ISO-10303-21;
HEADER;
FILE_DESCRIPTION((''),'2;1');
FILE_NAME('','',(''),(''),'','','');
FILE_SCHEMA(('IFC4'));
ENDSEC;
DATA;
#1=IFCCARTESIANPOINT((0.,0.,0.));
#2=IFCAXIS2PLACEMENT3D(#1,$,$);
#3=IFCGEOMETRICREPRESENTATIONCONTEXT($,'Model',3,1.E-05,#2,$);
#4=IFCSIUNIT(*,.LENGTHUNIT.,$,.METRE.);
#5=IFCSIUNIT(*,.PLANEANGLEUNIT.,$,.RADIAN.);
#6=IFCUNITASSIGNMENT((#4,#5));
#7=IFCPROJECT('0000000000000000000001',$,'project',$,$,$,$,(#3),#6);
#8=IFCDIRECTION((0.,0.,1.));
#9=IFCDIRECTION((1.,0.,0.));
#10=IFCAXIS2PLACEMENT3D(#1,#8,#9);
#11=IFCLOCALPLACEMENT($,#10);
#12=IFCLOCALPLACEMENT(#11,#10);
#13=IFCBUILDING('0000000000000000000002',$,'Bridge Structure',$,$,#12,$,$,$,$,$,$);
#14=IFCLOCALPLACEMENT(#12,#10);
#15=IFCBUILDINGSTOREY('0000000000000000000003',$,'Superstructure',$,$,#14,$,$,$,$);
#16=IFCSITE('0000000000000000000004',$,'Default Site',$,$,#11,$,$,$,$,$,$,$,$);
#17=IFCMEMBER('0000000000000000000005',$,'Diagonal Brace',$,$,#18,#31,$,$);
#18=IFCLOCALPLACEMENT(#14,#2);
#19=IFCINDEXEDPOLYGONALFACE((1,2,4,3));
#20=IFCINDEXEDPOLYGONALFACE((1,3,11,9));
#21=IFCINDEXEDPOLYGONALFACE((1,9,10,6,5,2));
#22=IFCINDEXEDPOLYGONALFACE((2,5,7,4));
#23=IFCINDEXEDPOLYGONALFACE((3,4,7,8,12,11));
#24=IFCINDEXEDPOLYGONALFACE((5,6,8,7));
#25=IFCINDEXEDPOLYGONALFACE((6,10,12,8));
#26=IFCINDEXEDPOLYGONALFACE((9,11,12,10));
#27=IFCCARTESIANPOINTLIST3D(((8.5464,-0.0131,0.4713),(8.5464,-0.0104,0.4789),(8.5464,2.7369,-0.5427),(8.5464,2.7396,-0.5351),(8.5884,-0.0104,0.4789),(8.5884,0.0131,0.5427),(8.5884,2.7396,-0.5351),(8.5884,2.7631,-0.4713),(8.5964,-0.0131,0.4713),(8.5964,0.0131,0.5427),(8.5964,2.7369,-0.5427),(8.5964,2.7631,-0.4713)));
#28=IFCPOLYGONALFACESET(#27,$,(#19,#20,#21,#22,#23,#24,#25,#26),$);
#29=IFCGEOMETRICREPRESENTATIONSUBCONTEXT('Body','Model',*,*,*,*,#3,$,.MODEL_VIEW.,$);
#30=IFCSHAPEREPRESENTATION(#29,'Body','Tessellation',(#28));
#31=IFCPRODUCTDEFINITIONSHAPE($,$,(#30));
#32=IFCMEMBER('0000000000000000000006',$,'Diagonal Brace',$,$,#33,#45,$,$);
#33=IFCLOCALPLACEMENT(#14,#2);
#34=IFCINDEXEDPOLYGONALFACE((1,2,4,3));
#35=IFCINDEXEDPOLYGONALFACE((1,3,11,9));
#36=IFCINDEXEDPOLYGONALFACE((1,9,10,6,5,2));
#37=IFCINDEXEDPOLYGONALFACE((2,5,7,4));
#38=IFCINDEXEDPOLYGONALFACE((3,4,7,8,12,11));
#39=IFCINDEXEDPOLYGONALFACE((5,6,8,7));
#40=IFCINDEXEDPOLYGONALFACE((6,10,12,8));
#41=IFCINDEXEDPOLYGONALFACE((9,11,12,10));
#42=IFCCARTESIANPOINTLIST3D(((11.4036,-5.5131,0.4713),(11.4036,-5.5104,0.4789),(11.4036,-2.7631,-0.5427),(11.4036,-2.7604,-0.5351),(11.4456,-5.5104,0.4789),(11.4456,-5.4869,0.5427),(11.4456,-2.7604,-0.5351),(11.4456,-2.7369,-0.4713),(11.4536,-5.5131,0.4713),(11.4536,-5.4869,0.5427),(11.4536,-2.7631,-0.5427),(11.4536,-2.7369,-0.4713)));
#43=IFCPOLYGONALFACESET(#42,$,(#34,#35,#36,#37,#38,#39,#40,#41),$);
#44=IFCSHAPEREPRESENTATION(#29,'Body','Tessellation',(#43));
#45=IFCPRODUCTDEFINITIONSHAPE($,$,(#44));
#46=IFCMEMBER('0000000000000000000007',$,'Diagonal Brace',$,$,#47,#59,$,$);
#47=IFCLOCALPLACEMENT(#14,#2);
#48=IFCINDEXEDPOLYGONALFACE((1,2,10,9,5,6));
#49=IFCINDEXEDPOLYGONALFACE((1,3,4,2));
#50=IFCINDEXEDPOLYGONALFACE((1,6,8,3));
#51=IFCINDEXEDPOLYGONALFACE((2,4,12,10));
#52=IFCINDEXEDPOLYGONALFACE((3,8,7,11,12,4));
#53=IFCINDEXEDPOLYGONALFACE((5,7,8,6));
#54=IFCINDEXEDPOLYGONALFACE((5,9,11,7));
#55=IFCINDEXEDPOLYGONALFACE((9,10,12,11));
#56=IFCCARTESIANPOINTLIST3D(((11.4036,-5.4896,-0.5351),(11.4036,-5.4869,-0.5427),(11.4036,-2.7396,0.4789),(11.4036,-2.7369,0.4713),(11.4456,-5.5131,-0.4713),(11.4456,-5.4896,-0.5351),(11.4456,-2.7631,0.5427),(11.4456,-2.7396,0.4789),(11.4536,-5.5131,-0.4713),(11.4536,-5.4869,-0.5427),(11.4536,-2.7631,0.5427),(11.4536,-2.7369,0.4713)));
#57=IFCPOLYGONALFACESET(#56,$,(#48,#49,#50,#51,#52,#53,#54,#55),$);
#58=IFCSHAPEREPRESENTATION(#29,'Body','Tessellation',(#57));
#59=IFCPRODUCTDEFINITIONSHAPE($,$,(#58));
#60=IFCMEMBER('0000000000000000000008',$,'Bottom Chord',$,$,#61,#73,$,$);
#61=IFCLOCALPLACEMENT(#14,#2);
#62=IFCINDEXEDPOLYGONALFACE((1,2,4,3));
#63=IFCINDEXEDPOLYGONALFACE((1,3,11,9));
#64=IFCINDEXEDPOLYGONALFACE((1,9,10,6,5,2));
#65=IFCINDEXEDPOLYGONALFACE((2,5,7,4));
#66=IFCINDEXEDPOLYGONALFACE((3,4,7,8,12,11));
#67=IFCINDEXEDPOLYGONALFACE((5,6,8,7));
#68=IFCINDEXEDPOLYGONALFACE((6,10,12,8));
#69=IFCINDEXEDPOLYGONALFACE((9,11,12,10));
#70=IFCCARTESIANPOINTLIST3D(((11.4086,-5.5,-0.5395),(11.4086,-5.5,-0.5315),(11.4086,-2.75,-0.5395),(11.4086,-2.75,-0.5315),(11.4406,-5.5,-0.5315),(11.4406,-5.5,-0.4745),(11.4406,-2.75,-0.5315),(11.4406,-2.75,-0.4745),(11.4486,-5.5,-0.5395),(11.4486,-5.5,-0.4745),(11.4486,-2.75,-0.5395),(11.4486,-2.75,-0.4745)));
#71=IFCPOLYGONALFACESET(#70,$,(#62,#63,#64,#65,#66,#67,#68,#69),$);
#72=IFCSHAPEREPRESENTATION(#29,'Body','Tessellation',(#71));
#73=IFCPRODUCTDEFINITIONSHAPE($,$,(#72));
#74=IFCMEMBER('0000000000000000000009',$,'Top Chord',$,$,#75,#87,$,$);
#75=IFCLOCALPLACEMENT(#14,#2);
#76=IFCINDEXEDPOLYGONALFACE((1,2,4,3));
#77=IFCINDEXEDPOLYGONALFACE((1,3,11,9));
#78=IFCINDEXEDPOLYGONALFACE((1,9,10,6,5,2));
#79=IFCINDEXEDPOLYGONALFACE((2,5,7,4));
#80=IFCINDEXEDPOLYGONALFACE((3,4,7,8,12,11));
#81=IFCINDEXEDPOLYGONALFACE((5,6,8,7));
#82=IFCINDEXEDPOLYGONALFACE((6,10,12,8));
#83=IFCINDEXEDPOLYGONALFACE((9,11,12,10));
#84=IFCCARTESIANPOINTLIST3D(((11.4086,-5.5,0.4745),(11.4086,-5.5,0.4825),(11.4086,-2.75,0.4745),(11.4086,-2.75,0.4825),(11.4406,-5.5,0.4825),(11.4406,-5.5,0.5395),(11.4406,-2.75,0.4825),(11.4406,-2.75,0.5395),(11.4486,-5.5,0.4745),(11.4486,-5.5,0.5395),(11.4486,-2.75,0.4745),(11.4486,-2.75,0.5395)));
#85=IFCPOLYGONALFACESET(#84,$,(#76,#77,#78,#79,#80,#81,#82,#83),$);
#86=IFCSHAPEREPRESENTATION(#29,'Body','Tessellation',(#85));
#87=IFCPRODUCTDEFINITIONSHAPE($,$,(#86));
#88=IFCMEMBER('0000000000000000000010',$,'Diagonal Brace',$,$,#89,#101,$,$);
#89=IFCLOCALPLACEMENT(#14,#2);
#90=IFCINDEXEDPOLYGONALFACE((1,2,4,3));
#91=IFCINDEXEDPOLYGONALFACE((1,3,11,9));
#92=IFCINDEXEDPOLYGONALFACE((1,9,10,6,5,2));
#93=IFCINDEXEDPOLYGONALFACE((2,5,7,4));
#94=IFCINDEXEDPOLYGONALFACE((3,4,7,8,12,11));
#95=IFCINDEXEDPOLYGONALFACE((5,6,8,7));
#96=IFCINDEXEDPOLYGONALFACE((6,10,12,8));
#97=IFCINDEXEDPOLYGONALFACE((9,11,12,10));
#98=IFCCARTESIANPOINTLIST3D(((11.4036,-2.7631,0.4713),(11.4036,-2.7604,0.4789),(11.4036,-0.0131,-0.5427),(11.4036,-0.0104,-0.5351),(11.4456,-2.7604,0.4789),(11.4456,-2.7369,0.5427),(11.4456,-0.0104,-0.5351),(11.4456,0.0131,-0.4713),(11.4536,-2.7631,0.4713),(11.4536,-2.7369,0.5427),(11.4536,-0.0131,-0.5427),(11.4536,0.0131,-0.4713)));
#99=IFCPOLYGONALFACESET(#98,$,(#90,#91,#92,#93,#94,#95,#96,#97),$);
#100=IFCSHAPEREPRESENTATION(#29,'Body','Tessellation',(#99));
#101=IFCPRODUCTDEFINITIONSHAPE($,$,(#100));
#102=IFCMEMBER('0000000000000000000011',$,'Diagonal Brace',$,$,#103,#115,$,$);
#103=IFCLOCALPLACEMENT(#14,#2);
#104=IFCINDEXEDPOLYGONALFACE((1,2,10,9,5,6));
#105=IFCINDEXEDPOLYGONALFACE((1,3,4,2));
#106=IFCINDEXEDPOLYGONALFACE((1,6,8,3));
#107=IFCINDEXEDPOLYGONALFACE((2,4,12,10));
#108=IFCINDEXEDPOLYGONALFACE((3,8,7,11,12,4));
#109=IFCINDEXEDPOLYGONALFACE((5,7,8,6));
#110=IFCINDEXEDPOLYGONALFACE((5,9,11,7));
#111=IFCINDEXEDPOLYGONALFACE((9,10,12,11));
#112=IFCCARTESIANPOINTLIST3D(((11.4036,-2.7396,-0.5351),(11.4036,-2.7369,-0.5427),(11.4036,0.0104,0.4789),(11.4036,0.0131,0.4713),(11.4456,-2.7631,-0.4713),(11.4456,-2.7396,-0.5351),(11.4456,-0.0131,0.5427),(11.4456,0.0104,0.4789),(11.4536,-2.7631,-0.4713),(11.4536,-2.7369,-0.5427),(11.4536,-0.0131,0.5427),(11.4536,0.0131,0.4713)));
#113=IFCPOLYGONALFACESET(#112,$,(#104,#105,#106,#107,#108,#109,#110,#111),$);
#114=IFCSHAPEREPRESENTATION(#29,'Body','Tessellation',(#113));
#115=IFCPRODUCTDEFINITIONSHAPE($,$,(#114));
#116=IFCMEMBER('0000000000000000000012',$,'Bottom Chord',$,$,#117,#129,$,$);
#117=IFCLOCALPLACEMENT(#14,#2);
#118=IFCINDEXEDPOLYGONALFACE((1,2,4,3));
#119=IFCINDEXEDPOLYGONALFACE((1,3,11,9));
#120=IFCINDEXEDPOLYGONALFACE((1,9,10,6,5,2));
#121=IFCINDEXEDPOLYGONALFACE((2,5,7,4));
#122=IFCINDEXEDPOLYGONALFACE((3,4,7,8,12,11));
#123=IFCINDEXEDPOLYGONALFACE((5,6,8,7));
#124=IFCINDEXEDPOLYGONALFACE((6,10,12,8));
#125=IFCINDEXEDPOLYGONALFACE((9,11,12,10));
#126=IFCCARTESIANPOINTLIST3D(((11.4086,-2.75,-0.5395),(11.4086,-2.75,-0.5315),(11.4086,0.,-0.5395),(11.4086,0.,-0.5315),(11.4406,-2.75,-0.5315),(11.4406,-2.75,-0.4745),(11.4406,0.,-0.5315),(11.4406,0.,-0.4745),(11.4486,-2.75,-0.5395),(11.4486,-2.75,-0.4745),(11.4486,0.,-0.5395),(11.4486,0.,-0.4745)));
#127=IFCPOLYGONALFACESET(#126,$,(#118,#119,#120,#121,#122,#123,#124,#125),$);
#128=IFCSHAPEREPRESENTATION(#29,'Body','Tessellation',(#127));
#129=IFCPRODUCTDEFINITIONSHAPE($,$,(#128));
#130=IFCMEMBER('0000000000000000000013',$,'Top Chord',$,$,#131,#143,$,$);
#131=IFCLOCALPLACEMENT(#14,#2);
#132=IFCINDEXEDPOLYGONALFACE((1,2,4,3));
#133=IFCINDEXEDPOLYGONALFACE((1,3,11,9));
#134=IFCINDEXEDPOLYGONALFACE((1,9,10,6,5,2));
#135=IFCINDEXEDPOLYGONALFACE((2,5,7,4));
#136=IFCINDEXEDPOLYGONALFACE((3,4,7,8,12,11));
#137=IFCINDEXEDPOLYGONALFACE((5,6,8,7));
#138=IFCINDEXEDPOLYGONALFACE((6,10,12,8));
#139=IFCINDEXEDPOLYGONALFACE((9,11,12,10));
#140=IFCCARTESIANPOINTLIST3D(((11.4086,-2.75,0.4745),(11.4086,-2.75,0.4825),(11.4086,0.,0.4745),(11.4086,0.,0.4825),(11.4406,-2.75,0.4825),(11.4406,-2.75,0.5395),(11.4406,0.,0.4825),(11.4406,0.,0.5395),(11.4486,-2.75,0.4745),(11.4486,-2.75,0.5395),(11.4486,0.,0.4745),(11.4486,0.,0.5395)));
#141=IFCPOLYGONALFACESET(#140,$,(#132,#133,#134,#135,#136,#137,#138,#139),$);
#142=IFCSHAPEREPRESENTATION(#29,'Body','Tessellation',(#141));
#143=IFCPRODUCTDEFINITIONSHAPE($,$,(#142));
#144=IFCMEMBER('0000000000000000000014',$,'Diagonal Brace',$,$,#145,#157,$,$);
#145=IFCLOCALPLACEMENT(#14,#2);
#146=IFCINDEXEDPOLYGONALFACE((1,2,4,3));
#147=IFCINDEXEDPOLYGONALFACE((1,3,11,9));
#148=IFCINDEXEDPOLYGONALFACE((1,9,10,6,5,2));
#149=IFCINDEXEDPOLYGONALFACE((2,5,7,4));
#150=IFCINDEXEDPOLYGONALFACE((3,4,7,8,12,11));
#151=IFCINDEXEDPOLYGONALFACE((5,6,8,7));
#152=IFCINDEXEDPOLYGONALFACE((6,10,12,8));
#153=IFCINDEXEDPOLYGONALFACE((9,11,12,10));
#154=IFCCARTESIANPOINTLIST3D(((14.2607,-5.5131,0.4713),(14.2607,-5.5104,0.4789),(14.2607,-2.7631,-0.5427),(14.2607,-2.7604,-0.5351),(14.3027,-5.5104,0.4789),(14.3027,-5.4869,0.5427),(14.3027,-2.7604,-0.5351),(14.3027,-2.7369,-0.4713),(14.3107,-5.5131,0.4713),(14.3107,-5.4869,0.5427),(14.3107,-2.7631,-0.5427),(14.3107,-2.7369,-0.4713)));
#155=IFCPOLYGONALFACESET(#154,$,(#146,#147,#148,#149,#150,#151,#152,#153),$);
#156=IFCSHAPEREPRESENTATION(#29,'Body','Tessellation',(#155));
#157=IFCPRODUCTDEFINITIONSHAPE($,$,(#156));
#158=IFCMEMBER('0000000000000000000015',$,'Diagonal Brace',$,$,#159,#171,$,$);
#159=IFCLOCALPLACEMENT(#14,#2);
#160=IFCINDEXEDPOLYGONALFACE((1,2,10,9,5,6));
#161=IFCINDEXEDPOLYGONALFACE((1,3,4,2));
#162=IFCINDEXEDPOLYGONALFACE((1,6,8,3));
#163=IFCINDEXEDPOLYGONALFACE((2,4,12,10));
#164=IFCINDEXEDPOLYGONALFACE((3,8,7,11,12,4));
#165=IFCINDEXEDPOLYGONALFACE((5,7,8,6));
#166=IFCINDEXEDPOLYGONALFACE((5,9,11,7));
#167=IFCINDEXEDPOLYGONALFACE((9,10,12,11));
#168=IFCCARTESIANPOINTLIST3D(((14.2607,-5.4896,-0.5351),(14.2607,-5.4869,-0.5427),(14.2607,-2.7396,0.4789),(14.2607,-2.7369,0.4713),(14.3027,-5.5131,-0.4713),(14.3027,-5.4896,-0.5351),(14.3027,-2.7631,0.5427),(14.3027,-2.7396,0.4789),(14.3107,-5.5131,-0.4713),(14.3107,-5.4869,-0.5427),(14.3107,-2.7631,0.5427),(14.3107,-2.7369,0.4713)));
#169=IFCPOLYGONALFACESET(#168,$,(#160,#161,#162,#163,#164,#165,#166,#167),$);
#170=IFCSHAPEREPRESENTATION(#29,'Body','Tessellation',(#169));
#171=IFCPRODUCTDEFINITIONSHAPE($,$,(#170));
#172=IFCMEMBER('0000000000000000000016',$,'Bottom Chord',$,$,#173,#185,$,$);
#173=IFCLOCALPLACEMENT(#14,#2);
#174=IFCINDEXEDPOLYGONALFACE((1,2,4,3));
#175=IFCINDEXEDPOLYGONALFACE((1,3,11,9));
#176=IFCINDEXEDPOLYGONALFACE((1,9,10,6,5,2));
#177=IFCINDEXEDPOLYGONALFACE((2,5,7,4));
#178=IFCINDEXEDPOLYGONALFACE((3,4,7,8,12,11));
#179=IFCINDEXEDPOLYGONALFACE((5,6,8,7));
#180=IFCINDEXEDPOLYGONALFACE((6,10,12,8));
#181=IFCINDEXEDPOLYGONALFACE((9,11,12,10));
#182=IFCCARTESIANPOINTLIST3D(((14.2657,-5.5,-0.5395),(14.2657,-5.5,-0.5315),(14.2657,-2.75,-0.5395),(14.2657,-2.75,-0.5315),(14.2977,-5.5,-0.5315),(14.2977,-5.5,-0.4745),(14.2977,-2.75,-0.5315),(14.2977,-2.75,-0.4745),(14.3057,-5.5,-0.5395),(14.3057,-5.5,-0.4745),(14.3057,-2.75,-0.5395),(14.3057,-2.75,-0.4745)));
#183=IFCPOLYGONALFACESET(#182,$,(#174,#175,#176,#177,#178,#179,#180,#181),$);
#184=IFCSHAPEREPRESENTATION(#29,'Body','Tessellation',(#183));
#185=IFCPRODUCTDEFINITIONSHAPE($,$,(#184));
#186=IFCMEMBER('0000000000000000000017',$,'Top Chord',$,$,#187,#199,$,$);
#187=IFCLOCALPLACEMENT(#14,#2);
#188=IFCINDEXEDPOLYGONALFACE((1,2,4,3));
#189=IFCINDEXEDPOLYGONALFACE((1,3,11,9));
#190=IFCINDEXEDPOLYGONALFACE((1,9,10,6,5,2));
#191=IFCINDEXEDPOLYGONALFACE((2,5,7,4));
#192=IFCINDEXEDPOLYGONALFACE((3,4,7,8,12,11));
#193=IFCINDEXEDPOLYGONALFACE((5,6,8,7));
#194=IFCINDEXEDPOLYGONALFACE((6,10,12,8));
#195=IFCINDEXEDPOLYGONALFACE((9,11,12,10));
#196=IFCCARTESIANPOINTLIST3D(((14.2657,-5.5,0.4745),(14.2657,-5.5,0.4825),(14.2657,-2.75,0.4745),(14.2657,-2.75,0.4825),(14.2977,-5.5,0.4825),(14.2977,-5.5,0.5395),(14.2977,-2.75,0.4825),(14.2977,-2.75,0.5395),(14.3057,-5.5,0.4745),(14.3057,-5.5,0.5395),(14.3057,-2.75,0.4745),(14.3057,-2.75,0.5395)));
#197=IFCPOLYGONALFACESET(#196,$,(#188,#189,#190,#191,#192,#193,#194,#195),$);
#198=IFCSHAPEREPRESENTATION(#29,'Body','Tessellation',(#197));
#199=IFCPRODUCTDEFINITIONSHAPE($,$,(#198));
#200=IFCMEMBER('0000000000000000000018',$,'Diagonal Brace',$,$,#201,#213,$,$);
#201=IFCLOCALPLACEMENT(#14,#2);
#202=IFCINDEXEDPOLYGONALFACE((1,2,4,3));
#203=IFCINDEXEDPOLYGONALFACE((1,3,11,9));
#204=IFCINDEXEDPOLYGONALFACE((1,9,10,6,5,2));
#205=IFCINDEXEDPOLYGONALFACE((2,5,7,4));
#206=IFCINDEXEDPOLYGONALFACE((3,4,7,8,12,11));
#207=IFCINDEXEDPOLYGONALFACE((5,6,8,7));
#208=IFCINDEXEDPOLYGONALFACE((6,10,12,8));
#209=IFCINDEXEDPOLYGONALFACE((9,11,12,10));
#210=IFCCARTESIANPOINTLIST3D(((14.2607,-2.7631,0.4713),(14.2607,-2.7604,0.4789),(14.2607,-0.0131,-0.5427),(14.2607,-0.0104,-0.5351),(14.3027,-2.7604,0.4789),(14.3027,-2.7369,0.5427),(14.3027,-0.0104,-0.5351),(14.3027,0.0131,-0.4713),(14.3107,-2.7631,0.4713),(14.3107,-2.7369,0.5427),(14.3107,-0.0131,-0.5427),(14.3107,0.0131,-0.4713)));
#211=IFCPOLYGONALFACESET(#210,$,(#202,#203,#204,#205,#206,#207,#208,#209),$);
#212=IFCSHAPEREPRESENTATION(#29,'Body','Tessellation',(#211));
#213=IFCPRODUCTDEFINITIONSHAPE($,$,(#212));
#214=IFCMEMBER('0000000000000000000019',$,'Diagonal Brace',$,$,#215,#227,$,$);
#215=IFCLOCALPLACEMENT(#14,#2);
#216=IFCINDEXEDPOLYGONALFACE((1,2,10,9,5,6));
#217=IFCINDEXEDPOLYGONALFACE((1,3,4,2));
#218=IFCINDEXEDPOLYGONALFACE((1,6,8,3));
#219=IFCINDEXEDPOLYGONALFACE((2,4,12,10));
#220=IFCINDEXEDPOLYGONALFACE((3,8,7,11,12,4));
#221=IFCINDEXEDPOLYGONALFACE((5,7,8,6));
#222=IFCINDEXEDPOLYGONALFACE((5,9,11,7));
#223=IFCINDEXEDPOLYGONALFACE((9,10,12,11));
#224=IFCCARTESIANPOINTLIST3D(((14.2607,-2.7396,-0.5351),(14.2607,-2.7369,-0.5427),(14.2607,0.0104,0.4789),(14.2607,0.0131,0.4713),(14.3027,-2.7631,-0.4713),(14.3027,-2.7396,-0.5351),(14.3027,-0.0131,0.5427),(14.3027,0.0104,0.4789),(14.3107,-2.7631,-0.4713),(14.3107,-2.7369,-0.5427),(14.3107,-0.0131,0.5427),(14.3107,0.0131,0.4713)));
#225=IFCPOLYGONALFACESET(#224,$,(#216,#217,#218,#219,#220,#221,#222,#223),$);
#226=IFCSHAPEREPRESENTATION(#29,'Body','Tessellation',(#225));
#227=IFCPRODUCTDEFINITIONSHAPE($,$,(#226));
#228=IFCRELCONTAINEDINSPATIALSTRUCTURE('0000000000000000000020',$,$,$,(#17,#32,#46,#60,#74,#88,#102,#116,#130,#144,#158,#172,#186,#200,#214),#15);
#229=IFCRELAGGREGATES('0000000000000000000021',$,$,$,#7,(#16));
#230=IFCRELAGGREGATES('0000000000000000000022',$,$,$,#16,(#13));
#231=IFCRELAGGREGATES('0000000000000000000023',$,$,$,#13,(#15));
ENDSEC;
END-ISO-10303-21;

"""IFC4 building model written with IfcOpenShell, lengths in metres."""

from ifc_helpers import new_model, si_unit, frame, origin, origin_with_axes, origin_2d_with_axis, place, context, subcontext, project, spatial, l_section, extrude, element, save


model = new_model("IFC4")

# Units and contexts
model_context = context("Model", 3, precision=1e-05, world=origin())
body_context = subcontext(model_context, "Body", "Model", "MODEL_VIEW")
ifc_project = project(units=[si_unit("LENGTHUNIT", "METRE"), si_unit("PLANEANGLEUNIT", "RADIAN")], contexts=[model_context])

# Site, building, storey
site_placement = place(None, origin_with_axes())
site = spatial("IfcSite", under=ifc_project, at=site_placement, Name="Default Site")
building_placement = place(site_placement, origin_with_axes())
building = spatial("IfcBuilding", under=site, at=building_placement, Name="Bridge Structure")
storey_placement = place(building_placement, origin_with_axes())
storey = spatial("IfcBuildingStorey", under=building, at=storey_placement, Name="Superstructure")

# Members
for number, where, z_axis, x_axis, name in (
    (1, (8.5714, 0.0, 0.507), (0.0, 0.93825, -0.345958), (-1.0, 0.0, 0.0), "Diagonal Brace"),
    (2, (11.4286, -5.5, 0.507), (0.0, 0.93825, -0.345958), (-1.0, 0.0, 0.0), "Diagonal Brace"),
    (3, (11.4286, -5.5, -0.507), (0.0, 0.93825, 0.345958), (-1.0, 0.0, 0.0), "Diagonal Brace"),
):
    element("IfcMember", number, at=place(storey_placement, frame(where, z_axis=z_axis, x_axis=x_axis)), inside=storey, Name=name, context=body_context, shape_type="SweptSolid", body=[
        extrude(l_section(Depth=0.076, Width=0.05, Thickness=0.008, at=origin_2d_with_axis()), origin_with_axes(), (0.0, 0.0, 1.0), 2.931),
    ])
for number, where, z_axis, x_axis, name in (
    (4, (11.4286, -5.5, -0.507), (0.0, 1.0, 0.0), (-1.0, 0.0, 0.0), "Bottom Chord"),
    (5, (11.4286, -5.5, 0.507), (0.0, 1.0, 0.0), (-1.0, 0.0, 0.0), "Top Chord"),
):
    element("IfcMember", number, at=place(storey_placement, frame(where, z_axis=z_axis, x_axis=x_axis)), inside=storey, Name=name, context=body_context, shape_type="SweptSolid", body=[
        extrude(l_section(Depth=0.065, Width=0.04, Thickness=0.008, at=origin_2d_with_axis()), origin_with_axes(), (0.0, 0.0, 1.0), 2.75),
    ])
for number, where, z_axis, x_axis, name in (
    (6, (11.4286, -2.75, 0.507), (0.0, 0.93825, -0.345958), (-1.0, 0.0, 0.0), "Diagonal Brace"),
    (7, (11.4286, -2.75, -0.507), (0.0, 0.93825, 0.345958), (-1.0, 0.0, 0.0), "Diagonal Brace"),
):
    element("IfcMember", number, at=place(storey_placement, frame(where, z_axis=z_axis, x_axis=x_axis)), inside=storey, Name=name, context=body_context, shape_type="SweptSolid", body=[
        extrude(l_section(Depth=0.076, Width=0.05, Thickness=0.008, at=origin_2d_with_axis()), origin_with_axes(), (0.0, 0.0, 1.0), 2.931),
    ])
for number, where, z_axis, x_axis, name in (
    (8, (11.4286, -2.75, -0.507), (0.0, 1.0, 0.0), (-1.0, 0.0, 0.0), "Bottom Chord"),
    (9, (11.4286, -2.75, 0.507), (0.0, 1.0, 0.0), (-1.0, 0.0, 0.0), "Top Chord"),
):
    element("IfcMember", number, at=place(storey_placement, frame(where, z_axis=z_axis, x_axis=x_axis)), inside=storey, Name=name, context=body_context, shape_type="SweptSolid", body=[
        extrude(l_section(Depth=0.065, Width=0.04, Thickness=0.008, at=origin_2d_with_axis()), origin_with_axes(), (0.0, 0.0, 1.0), 2.75),
    ])
for number, where, z_axis, x_axis, name in (
    (10, (14.2857, -5.5, 0.507), (0.0, 0.93825, -0.345958), (-1.0, 0.0, 0.0), "Diagonal Brace"),
    (11, (14.2857, -5.5, -0.507), (0.0, 0.93825, 0.345958), (-1.0, 0.0, 0.0), "Diagonal Brace"),
):
    element("IfcMember", number, at=place(storey_placement, frame(where, z_axis=z_axis, x_axis=x_axis)), inside=storey, Name=name, context=body_context, shape_type="SweptSolid", body=[
        extrude(l_section(Depth=0.076, Width=0.05, Thickness=0.008, at=origin_2d_with_axis()), origin_with_axes(), (0.0, 0.0, 1.0), 2.931),
    ])
for number, where, z_axis, x_axis, name in (
    (12, (14.2857, -5.5, -0.507), (0.0, 1.0, 0.0), (-1.0, 0.0, 0.0), "Bottom Chord"),
    (13, (14.2857, -5.5, 0.507), (0.0, 1.0, 0.0), (-1.0, 0.0, 0.0), "Top Chord"),
):
    element("IfcMember", number, at=place(storey_placement, frame(where, z_axis=z_axis, x_axis=x_axis)), inside=storey, Name=name, context=body_context, shape_type="SweptSolid", body=[
        extrude(l_section(Depth=0.065, Width=0.04, Thickness=0.008, at=origin_2d_with_axis()), origin_with_axes(), (0.0, 0.0, 1.0), 2.75),
    ])
for number, where, z_axis, x_axis, name in (
    (14, (14.2857, -2.75, 0.507), (0.0, 0.93825, -0.345958), (-1.0, 0.0, 0.0), "Diagonal Brace"),
    (15, (14.2857, -2.75, -0.507), (0.0, 0.93825, 0.345958), (-1.0, 0.0, 0.0), "Diagonal Brace"),
):
    element("IfcMember", number, at=place(storey_placement, frame(where, z_axis=z_axis, x_axis=x_axis)), inside=storey, Name=name, context=body_context, shape_type="SweptSolid", body=[
        extrude(l_section(Depth=0.076, Width=0.05, Thickness=0.008, at=origin_2d_with_axis()), origin_with_axes(), (0.0, 0.0, 1.0), 2.931),
    ])

save(model, "model.ifc")
